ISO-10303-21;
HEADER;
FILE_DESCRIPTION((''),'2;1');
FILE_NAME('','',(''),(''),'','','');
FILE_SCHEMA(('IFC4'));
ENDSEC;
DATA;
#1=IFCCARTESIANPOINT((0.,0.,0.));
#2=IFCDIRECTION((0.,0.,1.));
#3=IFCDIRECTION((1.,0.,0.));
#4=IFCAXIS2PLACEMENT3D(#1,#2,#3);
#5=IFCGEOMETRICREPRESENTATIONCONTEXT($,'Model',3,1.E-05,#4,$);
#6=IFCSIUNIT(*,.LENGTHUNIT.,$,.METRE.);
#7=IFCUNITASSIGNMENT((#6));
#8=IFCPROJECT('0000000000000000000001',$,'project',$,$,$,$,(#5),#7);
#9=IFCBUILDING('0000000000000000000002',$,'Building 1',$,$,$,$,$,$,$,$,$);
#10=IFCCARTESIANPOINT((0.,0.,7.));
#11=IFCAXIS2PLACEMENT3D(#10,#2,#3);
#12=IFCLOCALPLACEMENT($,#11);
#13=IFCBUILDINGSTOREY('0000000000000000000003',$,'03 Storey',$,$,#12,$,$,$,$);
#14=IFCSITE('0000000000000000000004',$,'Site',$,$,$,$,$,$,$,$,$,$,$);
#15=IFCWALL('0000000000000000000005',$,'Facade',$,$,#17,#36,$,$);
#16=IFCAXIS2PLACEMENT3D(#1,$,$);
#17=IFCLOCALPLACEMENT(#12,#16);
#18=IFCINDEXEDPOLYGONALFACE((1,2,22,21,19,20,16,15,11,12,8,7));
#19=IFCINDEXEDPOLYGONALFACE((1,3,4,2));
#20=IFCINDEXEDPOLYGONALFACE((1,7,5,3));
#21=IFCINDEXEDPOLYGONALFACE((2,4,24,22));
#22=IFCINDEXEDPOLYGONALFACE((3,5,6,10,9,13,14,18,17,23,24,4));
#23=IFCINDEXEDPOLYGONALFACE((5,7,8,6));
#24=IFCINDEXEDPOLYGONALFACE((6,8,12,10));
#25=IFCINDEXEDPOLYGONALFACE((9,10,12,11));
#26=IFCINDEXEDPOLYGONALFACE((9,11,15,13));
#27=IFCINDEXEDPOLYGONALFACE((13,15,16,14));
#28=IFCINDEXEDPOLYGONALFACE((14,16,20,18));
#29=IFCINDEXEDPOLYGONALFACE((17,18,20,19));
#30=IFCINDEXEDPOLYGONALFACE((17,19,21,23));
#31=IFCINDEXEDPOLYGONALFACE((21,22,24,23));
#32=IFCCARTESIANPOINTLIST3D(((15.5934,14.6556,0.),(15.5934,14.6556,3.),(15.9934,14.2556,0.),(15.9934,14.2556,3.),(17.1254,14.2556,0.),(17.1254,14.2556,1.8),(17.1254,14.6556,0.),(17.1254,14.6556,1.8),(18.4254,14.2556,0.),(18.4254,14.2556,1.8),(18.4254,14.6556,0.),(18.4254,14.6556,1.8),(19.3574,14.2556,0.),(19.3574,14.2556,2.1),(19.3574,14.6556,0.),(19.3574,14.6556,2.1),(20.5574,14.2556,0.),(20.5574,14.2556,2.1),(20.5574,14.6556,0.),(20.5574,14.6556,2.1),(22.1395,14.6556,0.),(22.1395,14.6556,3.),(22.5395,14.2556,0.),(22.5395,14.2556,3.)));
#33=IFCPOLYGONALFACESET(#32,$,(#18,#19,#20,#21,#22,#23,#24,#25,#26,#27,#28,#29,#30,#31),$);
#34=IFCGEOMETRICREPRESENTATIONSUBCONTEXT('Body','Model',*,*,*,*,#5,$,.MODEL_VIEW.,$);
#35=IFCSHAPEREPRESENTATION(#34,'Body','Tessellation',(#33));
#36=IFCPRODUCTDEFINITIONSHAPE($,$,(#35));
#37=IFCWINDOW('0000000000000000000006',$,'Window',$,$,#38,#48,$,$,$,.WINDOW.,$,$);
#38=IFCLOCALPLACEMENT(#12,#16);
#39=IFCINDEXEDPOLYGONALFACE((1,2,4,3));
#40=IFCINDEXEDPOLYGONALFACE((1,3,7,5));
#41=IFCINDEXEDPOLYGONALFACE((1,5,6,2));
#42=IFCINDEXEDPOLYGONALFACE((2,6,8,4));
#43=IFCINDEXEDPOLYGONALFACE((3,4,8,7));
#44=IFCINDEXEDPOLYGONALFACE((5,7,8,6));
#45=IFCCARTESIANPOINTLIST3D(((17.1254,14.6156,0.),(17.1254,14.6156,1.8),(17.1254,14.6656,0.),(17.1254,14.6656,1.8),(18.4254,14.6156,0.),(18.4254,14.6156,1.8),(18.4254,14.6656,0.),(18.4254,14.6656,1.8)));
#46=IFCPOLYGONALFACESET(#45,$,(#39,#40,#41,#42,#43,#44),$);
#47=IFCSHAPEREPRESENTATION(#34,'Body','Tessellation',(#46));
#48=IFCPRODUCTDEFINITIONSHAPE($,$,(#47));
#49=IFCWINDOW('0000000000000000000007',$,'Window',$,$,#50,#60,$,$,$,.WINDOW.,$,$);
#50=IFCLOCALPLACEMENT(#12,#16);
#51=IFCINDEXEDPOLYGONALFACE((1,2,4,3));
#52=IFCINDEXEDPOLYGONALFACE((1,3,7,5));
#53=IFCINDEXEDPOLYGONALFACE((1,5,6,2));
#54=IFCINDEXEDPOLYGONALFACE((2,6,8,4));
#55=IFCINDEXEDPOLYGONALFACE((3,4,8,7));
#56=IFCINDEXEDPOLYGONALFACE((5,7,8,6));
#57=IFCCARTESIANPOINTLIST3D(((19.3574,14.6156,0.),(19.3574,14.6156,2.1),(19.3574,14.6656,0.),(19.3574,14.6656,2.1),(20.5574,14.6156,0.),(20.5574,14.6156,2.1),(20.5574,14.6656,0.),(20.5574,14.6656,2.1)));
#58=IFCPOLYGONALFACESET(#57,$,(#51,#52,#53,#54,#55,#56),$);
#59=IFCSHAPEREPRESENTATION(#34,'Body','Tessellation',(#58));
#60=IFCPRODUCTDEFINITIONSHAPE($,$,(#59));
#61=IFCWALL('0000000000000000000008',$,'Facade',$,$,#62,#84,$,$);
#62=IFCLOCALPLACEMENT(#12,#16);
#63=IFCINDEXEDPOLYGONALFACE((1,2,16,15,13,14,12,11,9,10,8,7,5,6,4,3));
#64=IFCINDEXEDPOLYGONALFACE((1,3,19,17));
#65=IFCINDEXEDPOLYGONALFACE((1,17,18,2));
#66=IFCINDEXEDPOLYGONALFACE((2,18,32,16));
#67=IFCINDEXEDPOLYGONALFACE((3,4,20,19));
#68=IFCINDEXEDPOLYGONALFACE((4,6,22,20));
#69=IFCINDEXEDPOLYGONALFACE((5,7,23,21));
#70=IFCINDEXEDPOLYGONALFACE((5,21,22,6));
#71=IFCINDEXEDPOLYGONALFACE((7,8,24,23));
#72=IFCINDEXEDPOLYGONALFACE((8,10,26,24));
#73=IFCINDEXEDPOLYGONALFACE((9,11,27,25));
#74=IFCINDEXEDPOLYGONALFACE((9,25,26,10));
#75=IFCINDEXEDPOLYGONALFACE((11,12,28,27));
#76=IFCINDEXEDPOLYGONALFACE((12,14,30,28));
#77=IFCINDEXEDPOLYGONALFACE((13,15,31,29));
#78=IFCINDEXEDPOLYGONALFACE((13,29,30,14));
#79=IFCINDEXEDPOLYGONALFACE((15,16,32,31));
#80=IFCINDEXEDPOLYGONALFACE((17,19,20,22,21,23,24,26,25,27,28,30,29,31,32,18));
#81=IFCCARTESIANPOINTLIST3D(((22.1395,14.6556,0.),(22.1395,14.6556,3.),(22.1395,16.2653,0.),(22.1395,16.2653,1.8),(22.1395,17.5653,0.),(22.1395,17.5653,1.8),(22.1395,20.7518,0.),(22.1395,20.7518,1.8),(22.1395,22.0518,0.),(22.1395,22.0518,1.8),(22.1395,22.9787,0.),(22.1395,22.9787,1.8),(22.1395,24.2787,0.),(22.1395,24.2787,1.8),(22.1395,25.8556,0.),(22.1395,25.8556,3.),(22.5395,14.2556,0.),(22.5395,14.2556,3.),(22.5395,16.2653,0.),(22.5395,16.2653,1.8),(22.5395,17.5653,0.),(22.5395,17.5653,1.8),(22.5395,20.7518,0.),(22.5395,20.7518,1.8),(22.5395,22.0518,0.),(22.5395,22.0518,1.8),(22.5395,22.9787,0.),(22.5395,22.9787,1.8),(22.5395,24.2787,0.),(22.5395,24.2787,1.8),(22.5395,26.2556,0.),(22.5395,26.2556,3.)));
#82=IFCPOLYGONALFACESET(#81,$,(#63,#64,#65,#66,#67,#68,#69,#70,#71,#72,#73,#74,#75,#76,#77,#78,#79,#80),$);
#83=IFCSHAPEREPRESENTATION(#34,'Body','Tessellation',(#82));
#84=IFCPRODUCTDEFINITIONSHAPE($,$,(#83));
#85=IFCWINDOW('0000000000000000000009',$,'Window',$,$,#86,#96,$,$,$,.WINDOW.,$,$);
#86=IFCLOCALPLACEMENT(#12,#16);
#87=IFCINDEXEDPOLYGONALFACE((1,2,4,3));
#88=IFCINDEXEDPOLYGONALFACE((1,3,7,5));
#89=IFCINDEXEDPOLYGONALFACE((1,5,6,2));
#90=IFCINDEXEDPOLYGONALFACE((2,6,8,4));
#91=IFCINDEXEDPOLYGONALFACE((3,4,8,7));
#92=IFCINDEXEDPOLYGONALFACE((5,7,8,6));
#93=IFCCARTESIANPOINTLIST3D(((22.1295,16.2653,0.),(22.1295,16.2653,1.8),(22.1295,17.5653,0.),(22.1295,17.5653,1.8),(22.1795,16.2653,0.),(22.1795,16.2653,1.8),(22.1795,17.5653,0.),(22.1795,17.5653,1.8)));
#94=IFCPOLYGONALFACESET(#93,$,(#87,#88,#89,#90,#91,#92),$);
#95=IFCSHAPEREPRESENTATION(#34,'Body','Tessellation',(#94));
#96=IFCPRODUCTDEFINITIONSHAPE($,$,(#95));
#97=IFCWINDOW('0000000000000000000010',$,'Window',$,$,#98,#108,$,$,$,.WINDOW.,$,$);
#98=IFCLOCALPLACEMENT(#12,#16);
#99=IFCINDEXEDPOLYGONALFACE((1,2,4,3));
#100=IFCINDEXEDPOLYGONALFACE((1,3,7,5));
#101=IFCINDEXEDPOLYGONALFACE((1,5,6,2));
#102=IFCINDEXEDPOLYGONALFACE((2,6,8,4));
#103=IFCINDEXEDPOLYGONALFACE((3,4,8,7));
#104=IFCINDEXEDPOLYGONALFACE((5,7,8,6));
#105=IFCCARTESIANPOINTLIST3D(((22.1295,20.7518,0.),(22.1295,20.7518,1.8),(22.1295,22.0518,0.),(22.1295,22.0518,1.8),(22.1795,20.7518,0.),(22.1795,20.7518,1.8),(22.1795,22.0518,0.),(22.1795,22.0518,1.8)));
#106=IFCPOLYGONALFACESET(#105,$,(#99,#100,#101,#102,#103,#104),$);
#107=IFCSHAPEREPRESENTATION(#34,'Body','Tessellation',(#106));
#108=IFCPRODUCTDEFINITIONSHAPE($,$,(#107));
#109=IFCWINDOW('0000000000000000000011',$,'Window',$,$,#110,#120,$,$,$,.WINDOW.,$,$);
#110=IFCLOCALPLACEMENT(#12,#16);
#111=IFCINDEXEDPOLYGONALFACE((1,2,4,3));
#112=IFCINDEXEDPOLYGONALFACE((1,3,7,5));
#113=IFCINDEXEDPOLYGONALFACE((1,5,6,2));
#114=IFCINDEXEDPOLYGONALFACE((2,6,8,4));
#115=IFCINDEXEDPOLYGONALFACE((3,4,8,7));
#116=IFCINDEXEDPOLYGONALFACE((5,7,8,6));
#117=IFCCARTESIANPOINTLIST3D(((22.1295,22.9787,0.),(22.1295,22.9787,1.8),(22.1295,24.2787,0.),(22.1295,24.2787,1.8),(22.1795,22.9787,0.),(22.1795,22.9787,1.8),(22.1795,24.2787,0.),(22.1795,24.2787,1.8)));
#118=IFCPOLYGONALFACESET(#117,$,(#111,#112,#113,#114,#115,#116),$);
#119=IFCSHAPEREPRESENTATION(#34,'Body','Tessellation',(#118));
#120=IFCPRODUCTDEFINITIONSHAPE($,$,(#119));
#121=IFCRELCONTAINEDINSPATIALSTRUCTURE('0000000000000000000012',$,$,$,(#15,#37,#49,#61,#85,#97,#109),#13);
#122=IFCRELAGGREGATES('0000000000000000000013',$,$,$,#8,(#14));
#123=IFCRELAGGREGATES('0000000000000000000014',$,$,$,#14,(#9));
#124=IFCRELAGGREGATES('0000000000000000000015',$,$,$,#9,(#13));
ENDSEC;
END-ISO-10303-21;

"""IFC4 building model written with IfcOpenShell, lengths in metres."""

from ifc_helpers import new_model, si_unit, frame, origin_with_axes, place, context, subcontext, project, spatial, line, indexed_curve, outline, extrude, element, fill, save


model = new_model("IFC4")

# Units and contexts
model_context = context("Model", 3, precision=1e-05, world=origin_with_axes())
body_context = subcontext(model_context, "Body", "Model", "MODEL_VIEW")
ifc_project = project(units=[si_unit("LENGTHUNIT", "METRE")], contexts=[model_context])

# Site, building, storey
site = spatial("IfcSite", under=ifc_project, Name="Site")
building = spatial("IfcBuilding", under=site, Name="Building 1")
storey_placement = place(None, frame((0.0, 0.0, 7.0), z_axis=(0.0, 0.0, 1.0), x_axis=(1.0, 0.0, 0.0)))
storey = spatial("IfcBuildingStorey", under=building, at=storey_placement, Name="03 Storey")

# Walls, openings, windows
wall_1_placement = place(storey_placement, origin_with_axes())
wall_1 = element("IfcWall", 1, at=wall_1_placement, inside=storey, Name="Facade", context=body_context, shape_type="SweptSolid", body=[
    extrude(outline(indexed_curve([(15.5934, 14.6556), (22.1395, 14.6556), (22.5395, 14.2556), (15.9934, 14.2556)], segments=[line(1, 2), line(2, 3), line(3, 4)])), origin_with_axes(), (0.0, 0.0, 1.0), 3.0),
])
opening_1_placement = place(wall_1_placement, origin_with_axes())
opening_1 = element("IfcOpeningElement", 2, at=opening_1_placement, cuts=wall_1, context=body_context, shape_type="SweptSolid", body=[
    extrude(outline(indexed_curve([(17.1254, 14.2156), (17.1254, 14.7156), (18.4254, 14.7156), (18.4254, 14.2156)], segments=[line(1, 2), line(2, 3), line(3, 4)])), origin_with_axes(), (0.0, 0.0, 1.0), 1.8),
])
opening_2_placement = place(wall_1_placement, origin_with_axes())
opening_2 = element("IfcOpeningElement", 3, at=opening_2_placement, cuts=wall_1, context=body_context, shape_type="SweptSolid", body=[
    extrude(outline(indexed_curve([(19.3574, 14.2156), (19.3574, 14.7156), (20.5574, 14.7156), (20.5574, 14.2156)], segments=[line(1, 2), line(2, 3), line(3, 4)])), origin_with_axes(), (0.0, 0.0, 1.0), 2.1),
])
window_1_placement = place(storey_placement, origin_with_axes())
window_1 = element("IfcWindow", 4, at=window_1_placement, inside=storey, Name="Window", PredefinedType="WINDOW", context=body_context, shape_type="SweptSolid", body=[
    extrude(outline(indexed_curve([(17.1254, 14.6156), (17.1254, 14.6656), (18.4254, 14.6656), (18.4254, 14.6156)], segments=[line(1, 2), line(2, 3), line(3, 4)])), origin_with_axes(), (0.0, 0.0, 1.0), 1.8),
])
fill(opening_1, window_1)
window_2_placement = place(storey_placement, origin_with_axes())
window_2 = element("IfcWindow", 5, at=window_2_placement, inside=storey, Name="Window", PredefinedType="WINDOW", context=body_context, shape_type="SweptSolid", body=[
    extrude(outline(indexed_curve([(19.3574, 14.6156), (19.3574, 14.6656), (20.5574, 14.6656), (20.5574, 14.6156)], segments=[line(1, 2), line(2, 3), line(3, 4)])), origin_with_axes(), (0.0, 0.0, 1.0), 2.1),
])
fill(opening_2, window_2)
wall_2_placement = place(storey_placement, origin_with_axes())
wall_2 = element("IfcWall", 6, at=wall_2_placement, inside=storey, Name="Facade", context=body_context, shape_type="SweptSolid", body=[
    extrude(outline(indexed_curve([(22.1395, 14.6556), (22.1395, 25.8556), (22.5395, 26.2556), (22.5395, 14.2556)], segments=[line(1, 2), line(2, 3), line(3, 4)])), origin_with_axes(), (0.0, 0.0, 1.0), 3.0),
])
opening_3_placement = place(wall_2_placement, origin_with_axes())
opening_3 = element("IfcOpeningElement", 7, at=opening_3_placement, cuts=wall_2, context=body_context, shape_type="SweptSolid", body=[
    extrude(outline(indexed_curve([(22.5795, 16.2653), (22.0795, 16.2653), (22.0795, 17.5653), (22.5795, 17.5653)], segments=[line(1, 2), line(2, 3), line(3, 4)])), origin_with_axes(), (0.0, 0.0, 1.0), 1.8),
])
opening_4_placement = place(wall_2_placement, origin_with_axes())
opening_4 = element("IfcOpeningElement", 8, at=opening_4_placement, cuts=wall_2, context=body_context, shape_type="SweptSolid", body=[
    extrude(outline(indexed_curve([(22.5795, 20.7518), (22.0795, 20.7518), (22.0795, 22.0518), (22.5795, 22.0518)], segments=[line(1, 2), line(2, 3), line(3, 4)])), origin_with_axes(), (0.0, 0.0, 1.0), 1.8),
])
opening_5_placement = place(wall_2_placement, origin_with_axes())
opening_5 = element("IfcOpeningElement", 9, at=opening_5_placement, cuts=wall_2, context=body_context, shape_type="SweptSolid", body=[
    extrude(outline(indexed_curve([(22.5795, 22.9787), (22.0795, 22.9787), (22.0795, 24.2787), (22.5795, 24.2787)], segments=[line(1, 2), line(2, 3), line(3, 4)])), origin_with_axes(), (0.0, 0.0, 1.0), 1.8),
])
window_3_placement = place(storey_placement, origin_with_axes())
window_3 = element("IfcWindow", 10, at=window_3_placement, inside=storey, Name="Window", PredefinedType="WINDOW", context=body_context, shape_type="SweptSolid", body=[
    extrude(outline(indexed_curve([(22.1795, 16.2653), (22.1295, 16.2653), (22.1295, 17.5653), (22.1795, 17.5653)], segments=[line(1, 2), line(2, 3), line(3, 4)])), origin_with_axes(), (0.0, 0.0, 1.0), 1.8),
])
fill(opening_3, window_3)
window_4_placement = place(storey_placement, origin_with_axes())
window_4 = element("IfcWindow", 11, at=window_4_placement, inside=storey, Name="Window", PredefinedType="WINDOW", context=body_context, shape_type="SweptSolid", body=[
    extrude(outline(indexed_curve([(22.1795, 20.7518), (22.1295, 20.7518), (22.1295, 22.0518), (22.1795, 22.0518)], segments=[line(1, 2), line(2, 3), line(3, 4)])), origin_with_axes(), (0.0, 0.0, 1.0), 1.8),
])
fill(opening_4, window_4)
window_5_placement = place(storey_placement, origin_with_axes())
window_5 = element("IfcWindow", 12, at=window_5_placement, inside=storey, Name="Window", PredefinedType="WINDOW", context=body_context, shape_type="SweptSolid", body=[
    extrude(outline(indexed_curve([(22.1795, 22.9787), (22.1295, 22.9787), (22.1295, 24.2787), (22.1795, 24.2787)], segments=[line(1, 2), line(2, 3), line(3, 4)])), origin_with_axes(), (0.0, 0.0, 1.0), 1.8),
])
fill(opening_5, window_5)

save(model, "model.ifc")
